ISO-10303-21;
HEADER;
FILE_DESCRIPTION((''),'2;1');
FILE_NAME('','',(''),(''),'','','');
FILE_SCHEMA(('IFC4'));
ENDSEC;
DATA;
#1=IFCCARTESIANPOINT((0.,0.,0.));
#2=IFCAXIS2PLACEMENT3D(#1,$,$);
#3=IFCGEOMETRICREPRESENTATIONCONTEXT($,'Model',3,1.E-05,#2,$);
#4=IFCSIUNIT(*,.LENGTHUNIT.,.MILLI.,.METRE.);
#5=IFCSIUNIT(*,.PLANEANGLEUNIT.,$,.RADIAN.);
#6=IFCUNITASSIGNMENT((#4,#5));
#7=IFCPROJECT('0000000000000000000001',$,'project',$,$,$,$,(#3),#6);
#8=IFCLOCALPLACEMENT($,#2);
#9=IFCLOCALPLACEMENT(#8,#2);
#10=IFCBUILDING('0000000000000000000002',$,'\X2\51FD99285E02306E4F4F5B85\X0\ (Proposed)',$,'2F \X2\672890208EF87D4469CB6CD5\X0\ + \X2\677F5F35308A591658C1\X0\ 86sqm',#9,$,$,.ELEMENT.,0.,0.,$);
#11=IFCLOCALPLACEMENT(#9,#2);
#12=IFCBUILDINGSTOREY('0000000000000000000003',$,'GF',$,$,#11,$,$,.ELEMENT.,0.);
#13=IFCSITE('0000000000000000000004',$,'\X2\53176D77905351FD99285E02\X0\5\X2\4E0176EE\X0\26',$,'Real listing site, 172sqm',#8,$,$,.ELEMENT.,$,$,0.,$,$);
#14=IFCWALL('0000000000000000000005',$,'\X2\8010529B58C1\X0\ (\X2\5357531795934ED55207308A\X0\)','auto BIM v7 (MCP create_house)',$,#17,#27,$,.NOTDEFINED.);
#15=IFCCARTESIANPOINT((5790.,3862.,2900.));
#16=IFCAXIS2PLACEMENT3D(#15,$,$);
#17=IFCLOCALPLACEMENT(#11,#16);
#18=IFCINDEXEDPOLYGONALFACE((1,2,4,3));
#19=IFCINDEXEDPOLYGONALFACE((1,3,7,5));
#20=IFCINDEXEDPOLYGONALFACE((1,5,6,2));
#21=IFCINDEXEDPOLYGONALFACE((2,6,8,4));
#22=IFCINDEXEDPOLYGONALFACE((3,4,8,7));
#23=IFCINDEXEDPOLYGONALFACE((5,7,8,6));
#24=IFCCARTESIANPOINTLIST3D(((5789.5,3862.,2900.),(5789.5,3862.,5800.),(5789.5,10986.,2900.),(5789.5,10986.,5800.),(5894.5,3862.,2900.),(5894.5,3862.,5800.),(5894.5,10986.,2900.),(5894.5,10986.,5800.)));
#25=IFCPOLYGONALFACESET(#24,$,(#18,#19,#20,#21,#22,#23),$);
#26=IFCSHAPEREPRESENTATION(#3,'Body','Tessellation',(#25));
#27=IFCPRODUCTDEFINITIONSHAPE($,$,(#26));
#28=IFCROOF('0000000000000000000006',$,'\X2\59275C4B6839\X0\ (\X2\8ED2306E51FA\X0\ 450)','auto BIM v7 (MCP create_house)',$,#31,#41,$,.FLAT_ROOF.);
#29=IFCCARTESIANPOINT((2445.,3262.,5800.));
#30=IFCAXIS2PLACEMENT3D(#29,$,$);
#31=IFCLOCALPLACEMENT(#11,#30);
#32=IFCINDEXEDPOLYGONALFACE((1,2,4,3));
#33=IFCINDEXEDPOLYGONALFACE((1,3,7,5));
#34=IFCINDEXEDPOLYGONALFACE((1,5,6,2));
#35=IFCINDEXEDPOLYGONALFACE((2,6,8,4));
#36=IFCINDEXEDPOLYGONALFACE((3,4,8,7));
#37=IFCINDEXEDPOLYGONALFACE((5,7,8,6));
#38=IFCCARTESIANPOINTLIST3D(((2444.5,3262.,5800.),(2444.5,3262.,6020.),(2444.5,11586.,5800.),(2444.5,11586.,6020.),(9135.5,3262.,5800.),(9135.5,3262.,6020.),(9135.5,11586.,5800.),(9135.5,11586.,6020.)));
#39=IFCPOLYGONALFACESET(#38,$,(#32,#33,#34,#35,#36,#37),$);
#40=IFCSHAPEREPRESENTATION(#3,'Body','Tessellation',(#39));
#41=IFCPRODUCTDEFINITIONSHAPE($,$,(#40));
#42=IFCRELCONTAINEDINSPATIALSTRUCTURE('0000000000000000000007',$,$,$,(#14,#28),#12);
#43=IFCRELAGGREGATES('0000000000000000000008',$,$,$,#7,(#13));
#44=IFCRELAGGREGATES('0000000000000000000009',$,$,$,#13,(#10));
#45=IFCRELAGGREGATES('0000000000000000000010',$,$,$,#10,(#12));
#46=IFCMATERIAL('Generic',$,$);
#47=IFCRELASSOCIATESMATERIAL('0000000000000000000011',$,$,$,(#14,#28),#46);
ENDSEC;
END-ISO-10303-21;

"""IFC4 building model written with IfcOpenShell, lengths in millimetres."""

from ifc_helpers import new_model, si_unit, frame, frame_2d, origin, place, context, project, spatial, rectangle, extrude, material, element, save


model = new_model("IFC4")

# Units and contexts
model_context = context("Model", 3, precision=1e-05, world=origin())
ifc_project = project(units=[si_unit("LENGTHUNIT", "METRE", prefix="MILLI"), si_unit("PLANEANGLEUNIT", "RADIAN")], contexts=[model_context])

# Site, building, storey
site_placement = place(None, origin())
site = spatial("IfcSite", under=ifc_project, at=site_placement, Name="北海道函館市5丁目26", ObjectType="Real listing site, 172sqm", CompositionType="ELEMENT", RefElevation=0.0)
building_placement = place(site_placement, origin())
building = spatial("IfcBuilding", under=site, at=building_placement, Name="函館市の住宅 (Proposed)", ObjectType="2F 木造軸組構法 + 板張り外壁 86sqm", CompositionType="ELEMENT", ElevationOfRefHeight=0.0, ElevationOfTerrain=0.0)
storey_placement = place(building_placement, origin())
storey = spatial("IfcBuildingStorey", under=building, at=storey_placement, Name="GF", CompositionType="ELEMENT", Elevation=0.0)

# Shared definitions
ifc_material = material(Name="Generic")

# Wall
wall_1_placement = place(storey_placement, frame((5790.0, 3862.0, 2900.0)))
element("IfcWall", 1, at=wall_1_placement, inside=storey, material=ifc_material, Name="耐力壁 (南北間仕切り)", Description="auto BIM v7 (MCP create_house)", PredefinedType="NOTDEFINED", context=model_context, shape_type="SweptSolid", body=[
    extrude(rectangle(XDim=105.0, YDim=7124.0, at=frame_2d((52.0, 3562.0))), frame((5790.0, 3862.0, 2900.0)), (0.0, 0.0, 1.0), 2900.0),
])

# Roof
roof_placement = place(storey_placement, frame((2445.0, 3262.0, 5800.0)))
element("IfcRoof", 2, at=roof_placement, inside=storey, material=ifc_material, Name="大屋根 (軒の出 450)", Description="auto BIM v7 (MCP create_house)", PredefinedType="FLAT_ROOF", context=model_context, shape_type="SweptSolid", body=[
    extrude(rectangle(XDim=6691.0, YDim=8324.0, at=frame_2d((3345.0, 4162.0))), frame((2445.0, 3262.0, 5800.0)), (0.0, 0.0, 1.0), 220.0),
])

save(model, "model.ifc")
